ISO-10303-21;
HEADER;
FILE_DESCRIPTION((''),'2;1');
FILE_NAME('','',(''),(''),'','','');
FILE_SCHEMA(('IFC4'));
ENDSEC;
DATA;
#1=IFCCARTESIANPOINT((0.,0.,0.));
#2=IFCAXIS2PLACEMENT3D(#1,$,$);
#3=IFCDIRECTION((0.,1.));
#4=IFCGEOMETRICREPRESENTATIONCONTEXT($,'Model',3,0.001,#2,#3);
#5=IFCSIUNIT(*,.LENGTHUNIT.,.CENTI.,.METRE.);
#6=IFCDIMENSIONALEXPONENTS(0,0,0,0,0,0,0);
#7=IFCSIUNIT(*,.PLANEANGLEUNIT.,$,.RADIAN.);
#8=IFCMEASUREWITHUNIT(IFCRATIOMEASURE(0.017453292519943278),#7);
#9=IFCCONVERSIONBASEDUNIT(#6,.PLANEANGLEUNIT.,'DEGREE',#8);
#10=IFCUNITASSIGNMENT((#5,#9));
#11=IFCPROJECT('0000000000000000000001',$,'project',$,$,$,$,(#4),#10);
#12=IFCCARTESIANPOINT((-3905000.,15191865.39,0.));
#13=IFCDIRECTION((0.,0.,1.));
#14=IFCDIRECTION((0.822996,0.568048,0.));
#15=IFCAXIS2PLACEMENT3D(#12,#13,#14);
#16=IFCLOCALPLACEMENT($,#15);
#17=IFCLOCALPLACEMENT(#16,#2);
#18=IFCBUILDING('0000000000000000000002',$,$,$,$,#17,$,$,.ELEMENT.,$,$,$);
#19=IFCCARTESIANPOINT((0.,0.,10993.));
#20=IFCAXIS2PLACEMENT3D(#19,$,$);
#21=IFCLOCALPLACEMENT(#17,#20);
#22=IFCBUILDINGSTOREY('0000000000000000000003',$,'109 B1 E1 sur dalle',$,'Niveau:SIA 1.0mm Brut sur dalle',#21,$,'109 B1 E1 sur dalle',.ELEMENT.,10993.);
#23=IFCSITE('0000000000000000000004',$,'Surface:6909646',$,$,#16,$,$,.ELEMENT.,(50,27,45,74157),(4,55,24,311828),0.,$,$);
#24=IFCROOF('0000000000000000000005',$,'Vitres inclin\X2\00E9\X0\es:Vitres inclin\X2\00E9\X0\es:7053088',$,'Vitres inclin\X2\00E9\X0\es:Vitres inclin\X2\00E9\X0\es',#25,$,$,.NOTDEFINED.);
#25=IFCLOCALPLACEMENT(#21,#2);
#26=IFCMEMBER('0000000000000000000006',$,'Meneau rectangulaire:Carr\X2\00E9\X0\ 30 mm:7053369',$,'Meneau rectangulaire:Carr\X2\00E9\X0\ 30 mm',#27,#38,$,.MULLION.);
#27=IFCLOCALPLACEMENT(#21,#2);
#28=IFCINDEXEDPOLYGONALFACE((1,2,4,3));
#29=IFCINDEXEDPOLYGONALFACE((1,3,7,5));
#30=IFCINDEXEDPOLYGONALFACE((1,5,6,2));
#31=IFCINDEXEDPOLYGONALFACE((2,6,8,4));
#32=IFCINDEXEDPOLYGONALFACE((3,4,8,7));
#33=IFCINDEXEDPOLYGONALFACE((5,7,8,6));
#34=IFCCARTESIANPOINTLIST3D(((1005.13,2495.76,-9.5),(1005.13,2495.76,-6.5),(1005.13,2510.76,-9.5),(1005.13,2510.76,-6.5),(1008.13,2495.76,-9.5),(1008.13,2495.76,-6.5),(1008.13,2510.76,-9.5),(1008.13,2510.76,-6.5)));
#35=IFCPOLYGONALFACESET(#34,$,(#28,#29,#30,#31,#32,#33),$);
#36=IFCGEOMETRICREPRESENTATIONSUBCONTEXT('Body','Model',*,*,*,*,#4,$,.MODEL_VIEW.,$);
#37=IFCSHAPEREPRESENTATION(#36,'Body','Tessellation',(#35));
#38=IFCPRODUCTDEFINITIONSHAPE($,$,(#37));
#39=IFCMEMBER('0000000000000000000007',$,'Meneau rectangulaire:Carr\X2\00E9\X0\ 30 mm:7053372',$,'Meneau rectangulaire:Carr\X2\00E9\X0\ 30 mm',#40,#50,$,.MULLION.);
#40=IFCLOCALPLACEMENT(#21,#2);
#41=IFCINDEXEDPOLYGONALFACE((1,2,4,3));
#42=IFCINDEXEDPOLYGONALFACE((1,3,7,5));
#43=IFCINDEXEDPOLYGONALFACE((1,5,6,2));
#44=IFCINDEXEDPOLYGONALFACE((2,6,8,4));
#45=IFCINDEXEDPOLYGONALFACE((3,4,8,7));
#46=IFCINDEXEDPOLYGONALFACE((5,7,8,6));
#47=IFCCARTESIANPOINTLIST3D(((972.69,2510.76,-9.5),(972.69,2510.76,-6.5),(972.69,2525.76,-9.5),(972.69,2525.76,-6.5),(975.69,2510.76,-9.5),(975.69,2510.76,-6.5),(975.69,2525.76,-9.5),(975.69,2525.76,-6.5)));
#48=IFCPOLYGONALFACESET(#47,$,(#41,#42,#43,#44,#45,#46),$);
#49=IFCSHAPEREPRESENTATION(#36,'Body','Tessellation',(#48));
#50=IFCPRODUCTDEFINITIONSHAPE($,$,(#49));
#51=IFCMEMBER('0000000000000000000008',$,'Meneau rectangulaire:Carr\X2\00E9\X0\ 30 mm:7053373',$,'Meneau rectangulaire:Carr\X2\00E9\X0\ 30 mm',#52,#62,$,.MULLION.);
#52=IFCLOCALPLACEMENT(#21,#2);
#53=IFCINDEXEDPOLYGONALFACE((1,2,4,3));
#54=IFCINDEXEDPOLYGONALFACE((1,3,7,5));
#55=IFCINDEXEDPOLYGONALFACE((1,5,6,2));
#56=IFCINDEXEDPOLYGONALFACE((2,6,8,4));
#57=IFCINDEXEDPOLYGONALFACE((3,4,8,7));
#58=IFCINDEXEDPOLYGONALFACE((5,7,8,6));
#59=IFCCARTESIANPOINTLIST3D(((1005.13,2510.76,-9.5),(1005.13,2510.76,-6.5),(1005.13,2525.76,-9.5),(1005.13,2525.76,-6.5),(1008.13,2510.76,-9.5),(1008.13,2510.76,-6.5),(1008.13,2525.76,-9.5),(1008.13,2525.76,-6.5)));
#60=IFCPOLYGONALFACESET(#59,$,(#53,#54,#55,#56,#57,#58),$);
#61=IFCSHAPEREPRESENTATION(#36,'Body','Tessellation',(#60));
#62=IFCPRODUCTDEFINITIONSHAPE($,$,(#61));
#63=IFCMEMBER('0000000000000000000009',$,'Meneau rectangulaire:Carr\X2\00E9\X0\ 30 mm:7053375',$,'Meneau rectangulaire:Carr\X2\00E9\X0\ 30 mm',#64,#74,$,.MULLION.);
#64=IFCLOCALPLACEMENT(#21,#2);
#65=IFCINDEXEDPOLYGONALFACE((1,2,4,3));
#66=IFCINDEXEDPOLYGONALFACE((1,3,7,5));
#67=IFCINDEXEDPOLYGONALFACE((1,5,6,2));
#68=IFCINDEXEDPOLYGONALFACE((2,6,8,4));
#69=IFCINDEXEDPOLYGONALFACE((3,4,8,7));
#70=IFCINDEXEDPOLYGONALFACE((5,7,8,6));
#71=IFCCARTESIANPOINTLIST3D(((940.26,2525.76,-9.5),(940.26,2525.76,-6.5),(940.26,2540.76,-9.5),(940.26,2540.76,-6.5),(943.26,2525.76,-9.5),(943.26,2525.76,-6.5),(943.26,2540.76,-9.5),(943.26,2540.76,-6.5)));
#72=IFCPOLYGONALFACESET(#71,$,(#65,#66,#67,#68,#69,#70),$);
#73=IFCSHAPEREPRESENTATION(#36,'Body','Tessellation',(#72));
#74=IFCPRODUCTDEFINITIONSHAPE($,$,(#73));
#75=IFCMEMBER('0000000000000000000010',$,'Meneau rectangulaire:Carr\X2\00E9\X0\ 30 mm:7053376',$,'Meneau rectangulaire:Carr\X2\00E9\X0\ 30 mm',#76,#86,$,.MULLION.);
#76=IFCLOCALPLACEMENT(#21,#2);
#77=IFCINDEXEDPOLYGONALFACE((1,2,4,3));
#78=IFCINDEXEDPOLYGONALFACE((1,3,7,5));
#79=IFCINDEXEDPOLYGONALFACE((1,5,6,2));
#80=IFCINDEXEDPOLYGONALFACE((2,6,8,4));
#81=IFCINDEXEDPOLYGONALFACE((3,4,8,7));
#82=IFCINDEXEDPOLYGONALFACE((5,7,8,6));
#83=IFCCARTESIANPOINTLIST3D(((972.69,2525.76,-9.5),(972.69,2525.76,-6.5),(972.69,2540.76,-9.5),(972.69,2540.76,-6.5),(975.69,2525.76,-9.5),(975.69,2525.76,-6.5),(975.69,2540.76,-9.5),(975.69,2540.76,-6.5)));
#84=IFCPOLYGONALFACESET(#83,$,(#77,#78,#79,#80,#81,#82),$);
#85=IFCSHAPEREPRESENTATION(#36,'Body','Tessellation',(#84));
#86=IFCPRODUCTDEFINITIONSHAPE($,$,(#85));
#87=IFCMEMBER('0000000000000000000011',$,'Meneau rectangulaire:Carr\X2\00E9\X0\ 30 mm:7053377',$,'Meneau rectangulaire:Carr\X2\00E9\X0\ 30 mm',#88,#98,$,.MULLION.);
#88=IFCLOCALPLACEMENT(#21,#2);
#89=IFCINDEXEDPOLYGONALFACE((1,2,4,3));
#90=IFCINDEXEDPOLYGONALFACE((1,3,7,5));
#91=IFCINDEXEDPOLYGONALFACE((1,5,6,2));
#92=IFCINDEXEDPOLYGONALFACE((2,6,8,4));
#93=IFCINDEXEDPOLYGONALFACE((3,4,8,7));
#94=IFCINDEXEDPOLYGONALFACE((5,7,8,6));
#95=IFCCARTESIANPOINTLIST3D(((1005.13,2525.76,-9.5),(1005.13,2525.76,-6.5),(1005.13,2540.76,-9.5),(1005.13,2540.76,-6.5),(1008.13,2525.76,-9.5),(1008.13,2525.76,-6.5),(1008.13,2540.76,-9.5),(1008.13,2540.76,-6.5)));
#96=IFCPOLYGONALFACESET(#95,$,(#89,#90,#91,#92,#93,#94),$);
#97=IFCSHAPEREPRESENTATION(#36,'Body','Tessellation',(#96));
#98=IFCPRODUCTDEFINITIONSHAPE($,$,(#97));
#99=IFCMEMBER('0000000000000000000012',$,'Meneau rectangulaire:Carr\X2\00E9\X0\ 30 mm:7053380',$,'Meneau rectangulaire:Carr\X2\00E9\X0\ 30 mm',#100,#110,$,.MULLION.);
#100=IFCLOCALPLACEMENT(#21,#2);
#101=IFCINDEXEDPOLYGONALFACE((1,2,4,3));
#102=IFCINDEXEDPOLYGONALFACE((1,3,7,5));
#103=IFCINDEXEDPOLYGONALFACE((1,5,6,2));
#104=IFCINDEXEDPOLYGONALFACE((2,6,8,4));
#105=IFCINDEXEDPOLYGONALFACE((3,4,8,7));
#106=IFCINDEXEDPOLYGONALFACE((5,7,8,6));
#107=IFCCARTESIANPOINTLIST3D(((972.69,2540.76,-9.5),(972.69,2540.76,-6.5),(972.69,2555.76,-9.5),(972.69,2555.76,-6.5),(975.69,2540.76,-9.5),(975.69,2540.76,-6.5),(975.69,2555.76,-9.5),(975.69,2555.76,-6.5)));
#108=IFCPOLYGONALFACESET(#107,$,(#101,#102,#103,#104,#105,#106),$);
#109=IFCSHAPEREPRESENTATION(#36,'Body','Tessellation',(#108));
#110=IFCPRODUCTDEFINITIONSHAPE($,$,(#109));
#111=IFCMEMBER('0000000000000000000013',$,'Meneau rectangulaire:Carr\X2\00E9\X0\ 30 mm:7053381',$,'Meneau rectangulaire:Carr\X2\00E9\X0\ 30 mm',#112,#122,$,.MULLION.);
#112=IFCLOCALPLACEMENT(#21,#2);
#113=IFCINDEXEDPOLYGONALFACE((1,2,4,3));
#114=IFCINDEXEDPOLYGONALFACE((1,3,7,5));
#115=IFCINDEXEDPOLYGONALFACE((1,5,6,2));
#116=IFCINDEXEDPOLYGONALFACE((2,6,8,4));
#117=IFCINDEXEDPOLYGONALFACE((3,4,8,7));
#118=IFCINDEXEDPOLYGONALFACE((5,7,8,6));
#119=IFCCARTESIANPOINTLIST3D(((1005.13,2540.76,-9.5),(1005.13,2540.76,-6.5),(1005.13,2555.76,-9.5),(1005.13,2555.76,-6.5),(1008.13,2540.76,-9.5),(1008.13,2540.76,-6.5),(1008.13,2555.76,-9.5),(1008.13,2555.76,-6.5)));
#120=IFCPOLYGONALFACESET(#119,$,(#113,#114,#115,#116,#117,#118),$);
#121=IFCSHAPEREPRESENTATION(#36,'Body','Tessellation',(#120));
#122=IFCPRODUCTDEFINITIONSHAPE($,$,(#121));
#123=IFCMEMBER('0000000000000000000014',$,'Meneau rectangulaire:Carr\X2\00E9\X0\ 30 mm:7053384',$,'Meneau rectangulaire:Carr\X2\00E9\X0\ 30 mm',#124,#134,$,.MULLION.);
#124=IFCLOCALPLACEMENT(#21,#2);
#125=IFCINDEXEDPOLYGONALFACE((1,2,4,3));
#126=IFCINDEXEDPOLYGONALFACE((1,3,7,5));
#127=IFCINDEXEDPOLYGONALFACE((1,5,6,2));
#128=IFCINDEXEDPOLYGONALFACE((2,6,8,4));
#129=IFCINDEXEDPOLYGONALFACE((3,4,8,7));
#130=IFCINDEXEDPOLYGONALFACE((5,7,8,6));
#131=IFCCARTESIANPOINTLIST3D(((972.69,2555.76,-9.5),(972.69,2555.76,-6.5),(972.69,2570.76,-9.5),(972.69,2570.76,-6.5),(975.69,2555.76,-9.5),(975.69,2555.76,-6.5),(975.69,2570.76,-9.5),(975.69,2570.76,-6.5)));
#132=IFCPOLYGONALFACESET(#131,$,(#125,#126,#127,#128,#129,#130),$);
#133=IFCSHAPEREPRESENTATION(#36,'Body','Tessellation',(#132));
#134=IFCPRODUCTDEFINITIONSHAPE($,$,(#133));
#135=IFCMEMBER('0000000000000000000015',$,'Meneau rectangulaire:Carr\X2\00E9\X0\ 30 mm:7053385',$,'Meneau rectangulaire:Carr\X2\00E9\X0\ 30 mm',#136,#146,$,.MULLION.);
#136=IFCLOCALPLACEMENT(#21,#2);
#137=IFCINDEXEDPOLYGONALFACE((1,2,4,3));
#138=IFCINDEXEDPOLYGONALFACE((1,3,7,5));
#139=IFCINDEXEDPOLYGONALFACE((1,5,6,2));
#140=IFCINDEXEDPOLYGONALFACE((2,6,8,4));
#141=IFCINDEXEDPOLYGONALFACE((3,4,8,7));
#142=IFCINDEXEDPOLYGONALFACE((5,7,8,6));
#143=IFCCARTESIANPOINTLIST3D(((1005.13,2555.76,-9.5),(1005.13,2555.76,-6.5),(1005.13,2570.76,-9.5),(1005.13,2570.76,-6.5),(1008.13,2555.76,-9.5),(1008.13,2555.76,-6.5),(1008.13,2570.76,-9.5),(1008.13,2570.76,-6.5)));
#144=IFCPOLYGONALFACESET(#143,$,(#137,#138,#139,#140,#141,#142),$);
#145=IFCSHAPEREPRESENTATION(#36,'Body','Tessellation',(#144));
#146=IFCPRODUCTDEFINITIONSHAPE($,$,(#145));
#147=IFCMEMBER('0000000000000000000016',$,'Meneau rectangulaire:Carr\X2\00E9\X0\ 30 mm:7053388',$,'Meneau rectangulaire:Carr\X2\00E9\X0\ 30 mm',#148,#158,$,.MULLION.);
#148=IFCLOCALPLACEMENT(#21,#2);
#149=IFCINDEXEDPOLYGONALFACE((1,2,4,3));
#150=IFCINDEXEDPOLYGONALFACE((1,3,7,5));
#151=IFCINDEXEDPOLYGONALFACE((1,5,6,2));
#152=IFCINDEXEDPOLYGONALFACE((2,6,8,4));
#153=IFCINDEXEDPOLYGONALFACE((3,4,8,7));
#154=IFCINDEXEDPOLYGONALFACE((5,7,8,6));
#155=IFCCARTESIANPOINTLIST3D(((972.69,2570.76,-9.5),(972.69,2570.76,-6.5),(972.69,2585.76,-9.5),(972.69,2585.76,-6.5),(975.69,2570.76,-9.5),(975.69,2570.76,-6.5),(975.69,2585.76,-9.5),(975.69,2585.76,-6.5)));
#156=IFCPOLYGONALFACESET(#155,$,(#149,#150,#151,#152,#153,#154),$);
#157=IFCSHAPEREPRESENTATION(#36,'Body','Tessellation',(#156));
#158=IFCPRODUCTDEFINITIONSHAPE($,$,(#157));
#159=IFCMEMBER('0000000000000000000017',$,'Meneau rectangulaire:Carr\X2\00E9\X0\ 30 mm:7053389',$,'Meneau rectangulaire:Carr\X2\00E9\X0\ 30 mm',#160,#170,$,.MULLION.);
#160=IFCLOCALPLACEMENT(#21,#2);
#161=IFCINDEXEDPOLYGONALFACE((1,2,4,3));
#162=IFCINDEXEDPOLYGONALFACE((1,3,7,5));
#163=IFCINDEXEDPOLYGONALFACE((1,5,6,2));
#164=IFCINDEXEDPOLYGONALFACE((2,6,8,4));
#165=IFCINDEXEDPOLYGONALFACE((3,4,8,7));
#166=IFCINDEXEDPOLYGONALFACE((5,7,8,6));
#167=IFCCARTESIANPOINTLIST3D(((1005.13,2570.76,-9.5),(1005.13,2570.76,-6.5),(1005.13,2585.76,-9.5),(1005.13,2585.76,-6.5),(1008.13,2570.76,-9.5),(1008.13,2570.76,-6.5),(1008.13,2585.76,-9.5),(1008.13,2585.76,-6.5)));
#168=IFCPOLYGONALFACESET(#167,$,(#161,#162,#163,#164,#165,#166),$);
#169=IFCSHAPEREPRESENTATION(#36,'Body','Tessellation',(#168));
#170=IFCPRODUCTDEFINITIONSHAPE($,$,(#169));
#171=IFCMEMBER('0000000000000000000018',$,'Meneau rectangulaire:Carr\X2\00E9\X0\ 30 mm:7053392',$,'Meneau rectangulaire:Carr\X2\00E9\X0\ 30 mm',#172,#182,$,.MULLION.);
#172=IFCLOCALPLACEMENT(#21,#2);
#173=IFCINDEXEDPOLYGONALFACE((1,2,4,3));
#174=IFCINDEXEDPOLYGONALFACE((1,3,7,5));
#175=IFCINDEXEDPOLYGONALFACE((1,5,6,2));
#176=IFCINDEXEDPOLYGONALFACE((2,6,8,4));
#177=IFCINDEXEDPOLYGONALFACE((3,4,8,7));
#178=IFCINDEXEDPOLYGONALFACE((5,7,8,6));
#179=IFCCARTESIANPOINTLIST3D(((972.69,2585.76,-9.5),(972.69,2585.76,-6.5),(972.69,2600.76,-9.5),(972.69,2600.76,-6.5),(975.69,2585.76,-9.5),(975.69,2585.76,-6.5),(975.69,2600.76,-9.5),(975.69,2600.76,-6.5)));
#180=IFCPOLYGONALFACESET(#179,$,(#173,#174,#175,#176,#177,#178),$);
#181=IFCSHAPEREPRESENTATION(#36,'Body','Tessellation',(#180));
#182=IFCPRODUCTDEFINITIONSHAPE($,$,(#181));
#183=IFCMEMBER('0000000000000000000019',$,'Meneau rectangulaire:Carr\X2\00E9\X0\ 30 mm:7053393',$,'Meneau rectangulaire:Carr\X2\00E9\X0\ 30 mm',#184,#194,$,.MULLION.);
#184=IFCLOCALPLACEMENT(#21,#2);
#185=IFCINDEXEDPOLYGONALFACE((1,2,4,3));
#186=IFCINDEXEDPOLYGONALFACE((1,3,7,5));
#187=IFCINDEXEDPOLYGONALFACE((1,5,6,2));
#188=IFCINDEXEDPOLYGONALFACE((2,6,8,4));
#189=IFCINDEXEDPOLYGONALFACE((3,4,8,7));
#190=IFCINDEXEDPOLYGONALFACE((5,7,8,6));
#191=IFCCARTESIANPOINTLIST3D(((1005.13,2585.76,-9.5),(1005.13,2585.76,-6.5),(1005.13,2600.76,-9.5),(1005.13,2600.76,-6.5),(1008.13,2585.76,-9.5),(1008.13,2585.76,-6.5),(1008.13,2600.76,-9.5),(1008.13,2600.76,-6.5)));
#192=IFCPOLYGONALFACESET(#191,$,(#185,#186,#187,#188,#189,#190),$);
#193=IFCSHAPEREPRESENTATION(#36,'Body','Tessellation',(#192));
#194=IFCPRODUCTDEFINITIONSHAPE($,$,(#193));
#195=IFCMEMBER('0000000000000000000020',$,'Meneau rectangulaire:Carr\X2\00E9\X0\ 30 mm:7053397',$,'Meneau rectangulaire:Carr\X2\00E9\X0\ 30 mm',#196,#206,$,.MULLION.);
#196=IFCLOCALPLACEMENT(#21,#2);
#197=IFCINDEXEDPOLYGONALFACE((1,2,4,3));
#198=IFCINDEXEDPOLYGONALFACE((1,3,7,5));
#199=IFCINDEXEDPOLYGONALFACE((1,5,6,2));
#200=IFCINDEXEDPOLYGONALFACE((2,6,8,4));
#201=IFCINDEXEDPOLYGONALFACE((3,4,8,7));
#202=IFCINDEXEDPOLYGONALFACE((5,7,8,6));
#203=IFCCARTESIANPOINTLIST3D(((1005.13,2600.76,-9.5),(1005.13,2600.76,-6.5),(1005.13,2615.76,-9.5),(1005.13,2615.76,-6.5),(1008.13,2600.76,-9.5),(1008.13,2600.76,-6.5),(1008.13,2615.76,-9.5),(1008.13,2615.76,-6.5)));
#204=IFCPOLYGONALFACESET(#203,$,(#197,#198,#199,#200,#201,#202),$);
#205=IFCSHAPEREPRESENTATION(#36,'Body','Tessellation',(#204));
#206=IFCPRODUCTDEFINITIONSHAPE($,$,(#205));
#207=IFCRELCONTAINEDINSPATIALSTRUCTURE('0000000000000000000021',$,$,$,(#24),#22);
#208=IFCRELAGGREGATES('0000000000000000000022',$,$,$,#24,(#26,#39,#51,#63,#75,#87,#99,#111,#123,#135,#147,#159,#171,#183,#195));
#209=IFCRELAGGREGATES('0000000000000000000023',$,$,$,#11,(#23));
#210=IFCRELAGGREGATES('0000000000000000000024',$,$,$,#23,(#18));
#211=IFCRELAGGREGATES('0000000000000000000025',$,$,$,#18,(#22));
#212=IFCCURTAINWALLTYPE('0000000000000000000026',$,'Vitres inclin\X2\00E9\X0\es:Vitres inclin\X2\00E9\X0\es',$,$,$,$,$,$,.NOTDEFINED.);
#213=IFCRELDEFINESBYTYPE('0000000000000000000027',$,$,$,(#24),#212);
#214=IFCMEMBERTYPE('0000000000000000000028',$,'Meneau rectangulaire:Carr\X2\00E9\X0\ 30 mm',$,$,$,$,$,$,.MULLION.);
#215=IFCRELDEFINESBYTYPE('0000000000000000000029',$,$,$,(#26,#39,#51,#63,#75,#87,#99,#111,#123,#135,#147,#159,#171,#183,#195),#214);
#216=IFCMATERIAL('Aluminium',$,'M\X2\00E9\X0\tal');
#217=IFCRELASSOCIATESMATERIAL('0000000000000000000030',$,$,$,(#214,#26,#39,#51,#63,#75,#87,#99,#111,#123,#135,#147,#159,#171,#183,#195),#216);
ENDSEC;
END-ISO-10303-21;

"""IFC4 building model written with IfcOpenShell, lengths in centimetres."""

from ifc_helpers import new_model, entity, si_unit, converted_unit, direction, frame, origin, place, context, subcontext, project, spatial, indexed_curve, outline, extrude, source, transform, mapped, material, type_object, type_shapes, element, aggregate, save


model = new_model("IFC4")

# Units and contexts
model_context = context("Model", 3, precision=0.001, world=origin(), true_north=direction((0.0, 1.0)))
body_context = subcontext(model_context, "Body", "Model", "MODEL_VIEW")
ifc_project = project(units=[si_unit("LENGTHUNIT", "METRE", prefix="CENTI"), converted_unit("PLANEANGLEUNIT", "DEGREE", entity("IfcRatioMeasure", 0.017453292519943278), si_unit("PLANEANGLEUNIT", "RADIAN"), dimensions=[0, 0, 0, 0, 0, 0, 0])], contexts=[model_context])

# Site, building, storey
site_placement = place(None, frame((-3905000.0, 15191865.39, 0.0), z_axis=(0.0, 0.0, 1.0), x_axis=(0.822996, 0.568048, 0.0)))
site = spatial("IfcSite", under=ifc_project, at=site_placement, Name="Surface:6909646", CompositionType="ELEMENT", RefLatitude=(50, 27, 45, 74157), RefLongitude=(4, 55, 24, 311828), RefElevation=0.0)
building_placement = place(site_placement, origin())
building = spatial("IfcBuilding", under=site, at=building_placement, CompositionType="ELEMENT")
storey_placement = place(building_placement, frame((0.0, 0.0, 10993.0)))
storey = spatial("IfcBuildingStorey", under=building, at=storey_placement, Name="109 B1 E1 sur dalle", ObjectType="Niveau:SIA 1.0mm Brut sur dalle", LongName="109 B1 E1 sur dalle", CompositionType="ELEMENT", Elevation=10993.0)

# Roof, members
curtain_wall_type = type_object("IfcCurtainWallType", Name="Vitres inclinées:Vitres inclinées", PredefinedType="NOTDEFINED")
roof_placement = place(storey_placement, frame((0.0, 0.0, -10993.0)))
roof = element("IfcRoof", 1, at=roof_placement, inside=storey, type_object=curtain_wall_type, Name="Vitres inclinées:Vitres inclinées:7053088", ObjectType="Vitres inclinées:Vitres inclinées", PredefinedType="NOTDEFINED")
ifc_material = material(Name="Aluminium", Category="Métal")
member_type_1 = type_object("IfcMemberType", Name="Meneau rectangulaire:Carré 30 mm", PredefinedType="MULLION", material=ifc_material)
shared_shape_1 = source(origin(), body_context, "Body", "SweptSolid", [
    extrude(outline(indexed_curve([(-1.5, -1.5), (1.5, -1.5), (1.5, 1.5), (-1.5, 1.5), (-1.5, -1.5)], self_intersect=False)), frame((0.0, 0.0, -15.0), z_axis=(0.0, 0.0, 1.0), x_axis=(0.0, -1.0, 0.0)), (0.0, 0.0, 1.0), 15.0),
])
type_shapes(member_type_1, [shared_shape_1])
member_1_placement = place(roof_placement, frame((1006.63, 2510.76, 10985.0), z_axis=(0.0, 1.0, 0.0), x_axis=(1.0, 0.0, 0.0)))
member_1 = element("IfcMember", 2, at=member_1_placement, type_object=member_type_1, material=ifc_material, Name="Meneau rectangulaire:Carré 30 mm:7053369", ObjectType="Meneau rectangulaire:Carré 30 mm", PredefinedType="MULLION", context=body_context, shape_type="MappedRepresentation", body=[
    mapped(shared_shape_1, transform((0.0, 0.0, 0.0), scale=1.0)),
])
member_2_placement = place(roof_placement, frame((974.19, 2525.76, 10985.0), z_axis=(0.0, 1.0, 0.0), x_axis=(1.0, 0.0, 0.0)))
member_2 = element("IfcMember", 3, at=member_2_placement, type_object=member_type_1, material=ifc_material, Name="Meneau rectangulaire:Carré 30 mm:7053372", ObjectType="Meneau rectangulaire:Carré 30 mm", PredefinedType="MULLION", context=body_context, shape_type="MappedRepresentation", body=[
    mapped(shared_shape_1, transform((0.0, 0.0, 0.0), scale=1.0)),
])
member_3_placement = place(roof_placement, frame((1006.63, 2525.76, 10985.0), z_axis=(0.0, 1.0, 0.0), x_axis=(1.0, 0.0, 0.0)))
member_3 = element("IfcMember", 4, at=member_3_placement, type_object=member_type_1, material=ifc_material, Name="Meneau rectangulaire:Carré 30 mm:7053373", ObjectType="Meneau rectangulaire:Carré 30 mm", PredefinedType="MULLION", context=body_context, shape_type="MappedRepresentation", body=[
    mapped(shared_shape_1, transform((0.0, 0.0, 0.0), scale=1.0)),
])
member_4_placement = place(roof_placement, frame((941.76, 2540.76, 10985.0), z_axis=(0.0, 1.0, 0.0), x_axis=(1.0, 0.0, 0.0)))
member_4 = element("IfcMember", 5, at=member_4_placement, type_object=member_type_1, material=ifc_material, Name="Meneau rectangulaire:Carré 30 mm:7053375", ObjectType="Meneau rectangulaire:Carré 30 mm", PredefinedType="MULLION", context=body_context, shape_type="MappedRepresentation", body=[
    mapped(shared_shape_1, transform((0.0, 0.0, 0.0), scale=1.0)),
])
member_5_placement = place(roof_placement, frame((974.19, 2540.76, 10985.0), z_axis=(0.0, 1.0, 0.0), x_axis=(1.0, 0.0, 0.0)))
member_5 = element("IfcMember", 6, at=member_5_placement, type_object=member_type_1, material=ifc_material, Name="Meneau rectangulaire:Carré 30 mm:7053376", ObjectType="Meneau rectangulaire:Carré 30 mm", PredefinedType="MULLION", context=body_context, shape_type="MappedRepresentation", body=[
    mapped(shared_shape_1, transform((0.0, 0.0, 0.0), scale=1.0)),
])
member_6_placement = place(roof_placement, frame((1006.63, 2540.76, 10985.0), z_axis=(0.0, 1.0, 0.0), x_axis=(1.0, 0.0, 0.0)))
member_6 = element("IfcMember", 7, at=member_6_placement, type_object=member_type_1, material=ifc_material, Name="Meneau rectangulaire:Carré 30 mm:7053377", ObjectType="Meneau rectangulaire:Carré 30 mm", PredefinedType="MULLION", context=body_context, shape_type="MappedRepresentation", body=[
    mapped(shared_shape_1, transform((0.0, 0.0, 0.0), scale=1.0)),
])
member_7_placement = place(roof_placement, frame((974.19, 2555.76, 10985.0), z_axis=(0.0, 1.0, 0.0), x_axis=(1.0, 0.0, 0.0)))
member_7 = element("IfcMember", 8, at=member_7_placement, type_object=member_type_1, material=ifc_material, Name="Meneau rectangulaire:Carré 30 mm:7053380", ObjectType="Meneau rectangulaire:Carré 30 mm", PredefinedType="MULLION", context=body_context, shape_type="MappedRepresentation", body=[
    mapped(shared_shape_1, transform((0.0, 0.0, 0.0), scale=1.0)),
])
member_8_placement = place(roof_placement, frame((1006.63, 2555.76, 10985.0), z_axis=(0.0, 1.0, 0.0), x_axis=(1.0, 0.0, 0.0)))
member_8 = element("IfcMember", 9, at=member_8_placement, type_object=member_type_1, material=ifc_material, Name="Meneau rectangulaire:Carré 30 mm:7053381", ObjectType="Meneau rectangulaire:Carré 30 mm", PredefinedType="MULLION", context=body_context, shape_type="MappedRepresentation", body=[
    mapped(shared_shape_1, transform((0.0, 0.0, 0.0), scale=1.0)),
])
member_9_placement = place(roof_placement, frame((974.19, 2570.76, 10985.0), z_axis=(0.0, 1.0, 0.0), x_axis=(1.0, 0.0, 0.0)))
member_9 = element("IfcMember", 10, at=member_9_placement, type_object=member_type_1, material=ifc_material, Name="Meneau rectangulaire:Carré 30 mm:7053384", ObjectType="Meneau rectangulaire:Carré 30 mm", PredefinedType="MULLION", context=body_context, shape_type="MappedRepresentation", body=[
    mapped(shared_shape_1, transform((0.0, 0.0, 0.0), scale=1.0)),
])
member_10_placement = place(roof_placement, frame((1006.63, 2570.76, 10985.0), z_axis=(0.0, 1.0, 0.0), x_axis=(1.0, 0.0, 0.0)))
member_10 = element("IfcMember", 11, at=member_10_placement, type_object=member_type_1, material=ifc_material, Name="Meneau rectangulaire:Carré 30 mm:7053385", ObjectType="Meneau rectangulaire:Carré 30 mm", PredefinedType="MULLION", context=body_context, shape_type="MappedRepresentation", body=[
    mapped(shared_shape_1, transform((0.0, 0.0, 0.0), scale=1.0)),
])
member_11_placement = place(roof_placement, frame((974.19, 2585.76, 10985.0), z_axis=(0.0, 1.0, 0.0), x_axis=(1.0, 0.0, 0.0)))
member_11 = element("IfcMember", 12, at=member_11_placement, type_object=member_type_1, material=ifc_material, Name="Meneau rectangulaire:Carré 30 mm:7053388", ObjectType="Meneau rectangulaire:Carré 30 mm", PredefinedType="MULLION", context=body_context, shape_type="MappedRepresentation", body=[
    mapped(shared_shape_1, transform((0.0, 0.0, 0.0), scale=1.0)),
])
member_12_placement = place(roof_placement, frame((1006.63, 2585.76, 10985.0), z_axis=(0.0, 1.0, 0.0), x_axis=(1.0, 0.0, 0.0)))
member_12 = element("IfcMember", 13, at=member_12_placement, type_object=member_type_1, material=ifc_material, Name="Meneau rectangulaire:Carré 30 mm:7053389", ObjectType="Meneau rectangulaire:Carré 30 mm", PredefinedType="MULLION", context=body_context, shape_type="MappedRepresentation", body=[
    mapped(shared_shape_1, transform((0.0, 0.0, 0.0), scale=1.0)),
])
member_13_placement = place(roof_placement, frame((974.19, 2600.76, 10985.0), z_axis=(0.0, 1.0, 0.0), x_axis=(1.0, 0.0, 0.0)))
member_13 = element("IfcMember", 14, at=member_13_placement, type_object=member_type_1, material=ifc_material, Name="Meneau rectangulaire:Carré 30 mm:7053392", ObjectType="Meneau rectangulaire:Carré 30 mm", PredefinedType="MULLION", context=body_context, shape_type="MappedRepresentation", body=[
    mapped(shared_shape_1, transform((0.0, 0.0, 0.0), scale=1.0)),
])
member_14_placement = place(roof_placement, frame((1006.63, 2600.76, 10985.0), z_axis=(0.0, 1.0, 0.0), x_axis=(1.0, 0.0, 0.0)))
member_14 = element("IfcMember", 15, at=member_14_placement, type_object=member_type_1, material=ifc_material, Name="Meneau rectangulaire:Carré 30 mm:7053393", ObjectType="Meneau rectangulaire:Carré 30 mm", PredefinedType="MULLION", context=body_context, shape_type="MappedRepresentation", body=[
    mapped(shared_shape_1, transform((0.0, 0.0, 0.0), scale=1.0)),
])
member_15_placement = place(roof_placement, frame((1006.63, 2615.76, 10985.0), z_axis=(0.0, 1.0, 0.0), x_axis=(1.0, 0.0, 0.0)))
member_15 = element("IfcMember", 16, at=member_15_placement, type_object=member_type_1, material=ifc_material, Name="Meneau rectangulaire:Carré 30 mm:7053397", ObjectType="Meneau rectangulaire:Carré 30 mm", PredefinedType="MULLION", context=body_context, shape_type="MappedRepresentation", body=[
    mapped(shared_shape_1, transform((0.0, 0.0, 0.0), scale=1.0)),
])
aggregate(roof, [member_1, member_2, member_3, member_4, member_5, member_6, member_7, member_8, member_9, member_10, member_11, member_12, member_13, member_14, member_15])

save(model, "model.ifc")
